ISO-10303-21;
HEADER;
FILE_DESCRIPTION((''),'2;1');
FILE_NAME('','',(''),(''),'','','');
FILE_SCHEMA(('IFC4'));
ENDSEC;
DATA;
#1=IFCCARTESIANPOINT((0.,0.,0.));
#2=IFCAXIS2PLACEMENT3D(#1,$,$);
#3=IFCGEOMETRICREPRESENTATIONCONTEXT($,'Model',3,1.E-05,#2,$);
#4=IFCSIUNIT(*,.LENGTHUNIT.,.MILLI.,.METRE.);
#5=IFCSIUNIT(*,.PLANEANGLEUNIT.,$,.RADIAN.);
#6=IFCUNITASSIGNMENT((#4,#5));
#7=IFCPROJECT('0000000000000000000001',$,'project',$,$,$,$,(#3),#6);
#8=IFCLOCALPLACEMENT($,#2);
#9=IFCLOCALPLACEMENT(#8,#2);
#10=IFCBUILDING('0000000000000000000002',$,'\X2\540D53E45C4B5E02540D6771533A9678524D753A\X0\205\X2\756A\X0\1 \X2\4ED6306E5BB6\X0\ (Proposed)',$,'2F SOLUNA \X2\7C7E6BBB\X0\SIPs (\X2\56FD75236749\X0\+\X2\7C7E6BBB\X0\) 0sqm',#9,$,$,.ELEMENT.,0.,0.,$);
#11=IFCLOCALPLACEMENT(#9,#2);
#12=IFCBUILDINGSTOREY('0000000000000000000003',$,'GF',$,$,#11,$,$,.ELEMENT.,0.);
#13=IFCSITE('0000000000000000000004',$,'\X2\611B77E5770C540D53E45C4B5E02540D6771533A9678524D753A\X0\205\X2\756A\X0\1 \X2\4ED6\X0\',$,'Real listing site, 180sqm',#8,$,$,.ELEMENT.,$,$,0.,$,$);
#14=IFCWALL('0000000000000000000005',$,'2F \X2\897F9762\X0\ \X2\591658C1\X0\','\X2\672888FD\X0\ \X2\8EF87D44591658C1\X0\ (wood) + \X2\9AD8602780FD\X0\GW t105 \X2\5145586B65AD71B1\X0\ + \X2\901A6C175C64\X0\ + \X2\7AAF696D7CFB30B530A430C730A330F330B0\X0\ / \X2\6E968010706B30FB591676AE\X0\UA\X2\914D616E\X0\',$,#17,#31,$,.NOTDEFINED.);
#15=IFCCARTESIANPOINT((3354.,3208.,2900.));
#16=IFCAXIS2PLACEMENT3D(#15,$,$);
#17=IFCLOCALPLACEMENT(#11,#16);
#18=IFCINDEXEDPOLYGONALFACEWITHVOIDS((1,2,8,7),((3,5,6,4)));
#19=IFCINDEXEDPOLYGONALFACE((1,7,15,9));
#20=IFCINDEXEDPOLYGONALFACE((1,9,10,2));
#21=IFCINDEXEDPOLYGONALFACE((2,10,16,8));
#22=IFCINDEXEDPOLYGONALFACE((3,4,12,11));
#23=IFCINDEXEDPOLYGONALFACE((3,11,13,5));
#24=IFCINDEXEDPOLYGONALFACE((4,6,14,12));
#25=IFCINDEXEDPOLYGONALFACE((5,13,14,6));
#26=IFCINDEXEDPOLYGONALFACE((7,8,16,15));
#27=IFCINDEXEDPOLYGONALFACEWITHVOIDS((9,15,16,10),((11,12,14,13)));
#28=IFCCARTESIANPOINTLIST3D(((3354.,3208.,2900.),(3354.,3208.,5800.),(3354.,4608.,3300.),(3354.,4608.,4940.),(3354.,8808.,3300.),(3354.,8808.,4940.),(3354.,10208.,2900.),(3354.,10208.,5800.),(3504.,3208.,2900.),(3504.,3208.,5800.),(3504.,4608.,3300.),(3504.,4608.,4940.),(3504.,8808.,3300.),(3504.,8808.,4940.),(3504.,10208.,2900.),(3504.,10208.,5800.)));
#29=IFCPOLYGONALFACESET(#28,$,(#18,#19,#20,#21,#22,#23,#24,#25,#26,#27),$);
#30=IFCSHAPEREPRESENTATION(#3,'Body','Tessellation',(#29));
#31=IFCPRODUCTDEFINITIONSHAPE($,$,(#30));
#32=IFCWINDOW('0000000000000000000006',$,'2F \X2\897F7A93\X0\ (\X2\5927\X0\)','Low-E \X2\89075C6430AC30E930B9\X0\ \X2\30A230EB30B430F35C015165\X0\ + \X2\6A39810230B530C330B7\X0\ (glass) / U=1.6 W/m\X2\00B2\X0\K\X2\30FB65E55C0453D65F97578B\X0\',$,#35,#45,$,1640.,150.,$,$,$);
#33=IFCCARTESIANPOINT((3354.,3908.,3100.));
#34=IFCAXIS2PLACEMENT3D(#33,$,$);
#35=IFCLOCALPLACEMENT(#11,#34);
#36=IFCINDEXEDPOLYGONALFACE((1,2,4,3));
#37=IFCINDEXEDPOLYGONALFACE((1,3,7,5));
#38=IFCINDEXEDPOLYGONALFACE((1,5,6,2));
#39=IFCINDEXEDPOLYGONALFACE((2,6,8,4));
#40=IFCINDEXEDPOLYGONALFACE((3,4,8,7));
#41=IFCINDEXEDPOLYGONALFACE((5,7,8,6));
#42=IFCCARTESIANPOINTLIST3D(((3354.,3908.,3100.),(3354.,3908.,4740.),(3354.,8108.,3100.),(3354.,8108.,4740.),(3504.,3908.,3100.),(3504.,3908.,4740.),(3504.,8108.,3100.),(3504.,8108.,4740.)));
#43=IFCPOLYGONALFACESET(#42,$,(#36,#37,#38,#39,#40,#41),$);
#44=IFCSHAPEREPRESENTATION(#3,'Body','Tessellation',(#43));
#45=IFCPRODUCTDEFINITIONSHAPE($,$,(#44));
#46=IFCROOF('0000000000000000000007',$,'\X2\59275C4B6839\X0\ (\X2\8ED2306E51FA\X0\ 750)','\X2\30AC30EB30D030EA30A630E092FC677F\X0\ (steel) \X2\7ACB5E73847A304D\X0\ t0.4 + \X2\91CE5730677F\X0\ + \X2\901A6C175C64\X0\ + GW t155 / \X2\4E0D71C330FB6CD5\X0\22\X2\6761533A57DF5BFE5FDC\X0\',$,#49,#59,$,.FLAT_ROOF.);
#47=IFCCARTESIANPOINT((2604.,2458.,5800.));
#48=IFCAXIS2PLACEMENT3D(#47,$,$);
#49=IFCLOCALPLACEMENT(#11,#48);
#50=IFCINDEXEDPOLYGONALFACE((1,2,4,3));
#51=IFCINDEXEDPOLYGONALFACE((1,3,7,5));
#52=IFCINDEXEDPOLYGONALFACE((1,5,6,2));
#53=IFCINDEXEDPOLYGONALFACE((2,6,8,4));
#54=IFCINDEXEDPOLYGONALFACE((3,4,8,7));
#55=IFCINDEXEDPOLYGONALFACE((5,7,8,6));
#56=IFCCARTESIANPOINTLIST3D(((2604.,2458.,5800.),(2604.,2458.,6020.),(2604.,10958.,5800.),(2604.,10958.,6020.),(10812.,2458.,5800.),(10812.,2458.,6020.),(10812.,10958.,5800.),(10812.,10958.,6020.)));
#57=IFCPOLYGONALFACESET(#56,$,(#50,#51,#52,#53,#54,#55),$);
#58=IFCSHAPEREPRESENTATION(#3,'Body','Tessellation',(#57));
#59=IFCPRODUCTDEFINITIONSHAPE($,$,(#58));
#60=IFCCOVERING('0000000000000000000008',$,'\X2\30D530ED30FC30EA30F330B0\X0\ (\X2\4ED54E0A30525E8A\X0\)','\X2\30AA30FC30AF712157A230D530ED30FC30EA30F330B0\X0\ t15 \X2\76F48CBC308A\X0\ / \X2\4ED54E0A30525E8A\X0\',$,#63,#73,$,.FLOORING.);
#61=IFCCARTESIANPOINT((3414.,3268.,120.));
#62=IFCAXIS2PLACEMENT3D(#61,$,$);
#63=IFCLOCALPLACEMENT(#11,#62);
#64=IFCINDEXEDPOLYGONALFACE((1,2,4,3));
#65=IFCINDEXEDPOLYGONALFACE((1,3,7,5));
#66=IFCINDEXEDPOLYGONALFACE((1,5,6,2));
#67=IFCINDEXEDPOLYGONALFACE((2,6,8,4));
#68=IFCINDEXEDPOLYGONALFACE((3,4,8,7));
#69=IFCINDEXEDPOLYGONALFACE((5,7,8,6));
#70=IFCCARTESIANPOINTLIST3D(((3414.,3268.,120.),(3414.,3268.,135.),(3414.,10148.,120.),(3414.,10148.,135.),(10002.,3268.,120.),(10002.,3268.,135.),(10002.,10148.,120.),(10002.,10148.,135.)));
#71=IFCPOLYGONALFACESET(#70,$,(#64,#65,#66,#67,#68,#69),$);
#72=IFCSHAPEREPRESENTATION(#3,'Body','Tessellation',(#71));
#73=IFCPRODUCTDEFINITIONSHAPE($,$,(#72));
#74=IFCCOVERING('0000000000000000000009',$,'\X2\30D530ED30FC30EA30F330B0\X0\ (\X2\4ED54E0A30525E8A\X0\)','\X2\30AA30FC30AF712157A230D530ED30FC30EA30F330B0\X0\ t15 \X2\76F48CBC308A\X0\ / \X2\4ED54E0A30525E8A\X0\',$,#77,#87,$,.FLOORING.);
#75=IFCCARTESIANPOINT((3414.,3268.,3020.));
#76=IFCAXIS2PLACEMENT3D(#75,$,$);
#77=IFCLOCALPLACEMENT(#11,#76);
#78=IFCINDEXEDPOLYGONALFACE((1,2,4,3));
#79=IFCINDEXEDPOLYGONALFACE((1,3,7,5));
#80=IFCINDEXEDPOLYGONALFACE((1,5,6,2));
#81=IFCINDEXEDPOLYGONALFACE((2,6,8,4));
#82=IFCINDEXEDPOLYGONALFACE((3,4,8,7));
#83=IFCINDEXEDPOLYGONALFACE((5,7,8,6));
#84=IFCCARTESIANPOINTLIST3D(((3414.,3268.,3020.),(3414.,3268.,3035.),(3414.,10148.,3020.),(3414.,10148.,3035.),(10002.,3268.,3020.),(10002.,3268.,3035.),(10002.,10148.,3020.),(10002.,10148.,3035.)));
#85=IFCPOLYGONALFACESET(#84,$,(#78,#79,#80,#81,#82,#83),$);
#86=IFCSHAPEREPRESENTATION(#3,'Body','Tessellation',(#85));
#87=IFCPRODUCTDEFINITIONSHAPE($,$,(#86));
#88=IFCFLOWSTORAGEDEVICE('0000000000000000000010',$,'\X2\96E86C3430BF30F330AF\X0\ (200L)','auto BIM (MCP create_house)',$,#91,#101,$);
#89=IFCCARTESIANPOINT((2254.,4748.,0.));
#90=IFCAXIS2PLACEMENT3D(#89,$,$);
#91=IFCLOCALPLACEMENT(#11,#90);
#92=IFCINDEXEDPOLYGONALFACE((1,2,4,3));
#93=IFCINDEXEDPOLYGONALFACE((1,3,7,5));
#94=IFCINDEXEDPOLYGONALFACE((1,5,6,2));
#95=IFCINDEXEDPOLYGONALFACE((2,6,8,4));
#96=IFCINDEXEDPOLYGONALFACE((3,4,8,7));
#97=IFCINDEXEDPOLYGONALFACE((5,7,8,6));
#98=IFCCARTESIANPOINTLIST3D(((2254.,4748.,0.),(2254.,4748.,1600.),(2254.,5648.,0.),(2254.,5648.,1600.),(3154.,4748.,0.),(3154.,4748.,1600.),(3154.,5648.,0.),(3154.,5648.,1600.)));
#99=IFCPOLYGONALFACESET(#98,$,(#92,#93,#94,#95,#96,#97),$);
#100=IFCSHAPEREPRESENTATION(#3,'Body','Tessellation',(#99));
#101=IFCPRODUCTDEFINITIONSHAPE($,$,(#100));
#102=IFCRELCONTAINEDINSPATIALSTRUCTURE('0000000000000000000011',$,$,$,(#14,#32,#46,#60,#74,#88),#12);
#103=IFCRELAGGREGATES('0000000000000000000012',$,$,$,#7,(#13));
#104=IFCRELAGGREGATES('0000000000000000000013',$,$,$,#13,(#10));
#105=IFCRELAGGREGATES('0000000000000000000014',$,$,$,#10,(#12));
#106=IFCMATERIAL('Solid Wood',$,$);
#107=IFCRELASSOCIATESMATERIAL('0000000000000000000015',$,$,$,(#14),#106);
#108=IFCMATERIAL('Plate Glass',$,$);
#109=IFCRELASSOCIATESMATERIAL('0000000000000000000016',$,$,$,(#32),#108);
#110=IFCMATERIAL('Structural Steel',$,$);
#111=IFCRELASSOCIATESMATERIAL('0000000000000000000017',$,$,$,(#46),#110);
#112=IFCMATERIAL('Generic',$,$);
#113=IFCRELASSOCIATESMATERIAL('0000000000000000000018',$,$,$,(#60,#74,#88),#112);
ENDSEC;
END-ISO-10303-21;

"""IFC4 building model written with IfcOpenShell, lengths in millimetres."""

from ifc_helpers import new_model, si_unit, frame, frame_2d, origin, place, context, project, spatial, rectangle, extrude, material, element, fill, save


model = new_model("IFC4")

# Units and contexts
model_context = context("Model", 3, precision=1e-05, world=origin())
ifc_project = project(units=[si_unit("LENGTHUNIT", "METRE", prefix="MILLI"), si_unit("PLANEANGLEUNIT", "RADIAN")], contexts=[model_context])

# Site, building, storey
site_placement = place(None, origin())
site = spatial("IfcSite", under=ifc_project, at=site_placement, Name="愛知県名古屋市名東区陸前町205番1 他", ObjectType="Real listing site, 180sqm", CompositionType="ELEMENT", RefElevation=0.0)
building_placement = place(site_placement, origin())
building = spatial("IfcBuilding", under=site, at=building_placement, Name="名古屋市名東区陸前町205番1 他の家 (Proposed)", ObjectType="2F SOLUNA 籾殻SIPs (国産杉+籾殻) 0sqm", CompositionType="ELEMENT", ElevationOfRefHeight=0.0, ElevationOfTerrain=0.0)
storey_placement = place(building_placement, origin())
storey = spatial("IfcBuildingStorey", under=building, at=storey_placement, Name="GF", CompositionType="ELEMENT", Elevation=0.0)

# Shared definitions
ifc_material_1 = material(Name="Solid Wood")

# Shared definitions
ifc_material_2 = material(Name="Plate Glass")

# Wall, opening, window
wall_1_placement = place(storey_placement, frame((3354.0, 3208.0, 2900.0)))
wall_1 = element("IfcWall", 1, at=wall_1_placement, inside=storey, material=ifc_material_1, Name="2F 西面 外壁", Description="木製 軸組外壁 (wood) + 高性能GW t105 充填断熱 + 通気層 + 窯業系サイディング / 準耐火・外皮UA配慮", PredefinedType="NOTDEFINED", context=model_context, shape_type="SweptSolid", body=[
    extrude(rectangle(XDim=150.0, YDim=7000.0, at=frame_2d((75.0, 3500.0))), frame((3354.0, 3208.0, 2900.0)), (0.0, 0.0, 1.0), 2900.0),
])
opening_1_placement = place(storey_placement, frame((3354.0, 3908.0, 3100.0)))
opening_1 = element("IfcOpeningElement", 2, at=opening_1_placement, cuts=wall_1, PredefinedType="NOTDEFINED", context=model_context, shape_type="SweptSolid", body=[
    extrude(rectangle(XDim=150.0, YDim=4200.0, at=frame_2d((75.0, 2100.0))), frame((3354.0, 3908.0, 3100.0)), (0.0, 0.0, 1.0), 1640.0),
])
window_1_placement = place(storey_placement, frame((3354.0, 3908.0, 3100.0)))
window_1 = element("IfcWindow", 3, at=window_1_placement, inside=storey, material=ifc_material_2, Name="2F 西窓 (大)", Description="Low-E 複層ガラス アルゴン封入 + 樹脂サッシ (glass) / U=1.6 W/m²K・日射取得型", OverallHeight=1640.0, OverallWidth=150.0, context=model_context, shape_type="SweptSolid", body=[
    extrude(rectangle(XDim=150.0, YDim=4200.0, at=frame_2d((75.0, 2100.0))), frame((3354.0, 3908.0, 3100.0)), (0.0, 0.0, 1.0), 1640.0),
])
fill(opening_1, window_1)

# Roof
ifc_material_3 = material(Name="Structural Steel")
roof_placement = place(storey_placement, frame((2604.0, 2458.0, 5800.0)))
element("IfcRoof", 4, at=roof_placement, inside=storey, material=ifc_material_3, Name="大屋根 (軒の出 750)", Description="ガルバリウム鋼板 (steel) 立平葺き t0.4 + 野地板 + 通気層 + GW t155 / 不燃・法22条区域対応", PredefinedType="FLAT_ROOF", context=model_context, shape_type="SweptSolid", body=[
    extrude(rectangle(XDim=8208.0, YDim=8500.0, at=frame_2d((4104.0, 4250.0))), frame((2604.0, 2458.0, 5800.0)), (0.0, 0.0, 1.0), 220.0),
])

# Coverings
ifc_material_4 = material(Name="Generic")
covering_1_placement = place(storey_placement, frame((3414.0, 3268.0, 120.0)))
element("IfcCovering", 5, at=covering_1_placement, inside=storey, material=ifc_material_4, Name="フローリング (仕上げ床)", Description="オーク無垢フローリング t15 直貼り / 仕上げ床", PredefinedType="FLOORING", context=model_context, shape_type="SweptSolid", body=[
    extrude(rectangle(XDim=6588.0, YDim=6880.0, at=frame_2d((3294.0, 3440.0))), frame((3414.0, 3268.0, 120.0)), (0.0, 0.0, 1.0), 15.0),
])
covering_2_placement = place(storey_placement, frame((3414.0, 3268.0, 3020.0)))
element("IfcCovering", 6, at=covering_2_placement, inside=storey, material=ifc_material_4, Name="フローリング (仕上げ床)", Description="オーク無垢フローリング t15 直貼り / 仕上げ床", PredefinedType="FLOORING", context=model_context, shape_type="SweptSolid", body=[
    extrude(rectangle(XDim=6588.0, YDim=6880.0, at=frame_2d((3294.0, 3440.0))), frame((3414.0, 3268.0, 3020.0)), (0.0, 0.0, 1.0), 15.0),
])

# Flow storage device
flow_storage_device_placement = place(storey_placement, frame((2254.0, 4748.0, 0.0)))
element("IfcFlowStorageDevice", 7, at=flow_storage_device_placement, inside=storey, material=ifc_material_4, Name="雨水タンク (200L)", Description="auto BIM (MCP create_house)", context=model_context, shape_type="SweptSolid", body=[
    extrude(rectangle(XDim=900.0, YDim=900.0, at=frame_2d((450.0, 450.0))), frame((2254.0, 4748.0, 0.0)), (0.0, 0.0, 1.0), 1600.0),
])

save(model, "model.ifc")
